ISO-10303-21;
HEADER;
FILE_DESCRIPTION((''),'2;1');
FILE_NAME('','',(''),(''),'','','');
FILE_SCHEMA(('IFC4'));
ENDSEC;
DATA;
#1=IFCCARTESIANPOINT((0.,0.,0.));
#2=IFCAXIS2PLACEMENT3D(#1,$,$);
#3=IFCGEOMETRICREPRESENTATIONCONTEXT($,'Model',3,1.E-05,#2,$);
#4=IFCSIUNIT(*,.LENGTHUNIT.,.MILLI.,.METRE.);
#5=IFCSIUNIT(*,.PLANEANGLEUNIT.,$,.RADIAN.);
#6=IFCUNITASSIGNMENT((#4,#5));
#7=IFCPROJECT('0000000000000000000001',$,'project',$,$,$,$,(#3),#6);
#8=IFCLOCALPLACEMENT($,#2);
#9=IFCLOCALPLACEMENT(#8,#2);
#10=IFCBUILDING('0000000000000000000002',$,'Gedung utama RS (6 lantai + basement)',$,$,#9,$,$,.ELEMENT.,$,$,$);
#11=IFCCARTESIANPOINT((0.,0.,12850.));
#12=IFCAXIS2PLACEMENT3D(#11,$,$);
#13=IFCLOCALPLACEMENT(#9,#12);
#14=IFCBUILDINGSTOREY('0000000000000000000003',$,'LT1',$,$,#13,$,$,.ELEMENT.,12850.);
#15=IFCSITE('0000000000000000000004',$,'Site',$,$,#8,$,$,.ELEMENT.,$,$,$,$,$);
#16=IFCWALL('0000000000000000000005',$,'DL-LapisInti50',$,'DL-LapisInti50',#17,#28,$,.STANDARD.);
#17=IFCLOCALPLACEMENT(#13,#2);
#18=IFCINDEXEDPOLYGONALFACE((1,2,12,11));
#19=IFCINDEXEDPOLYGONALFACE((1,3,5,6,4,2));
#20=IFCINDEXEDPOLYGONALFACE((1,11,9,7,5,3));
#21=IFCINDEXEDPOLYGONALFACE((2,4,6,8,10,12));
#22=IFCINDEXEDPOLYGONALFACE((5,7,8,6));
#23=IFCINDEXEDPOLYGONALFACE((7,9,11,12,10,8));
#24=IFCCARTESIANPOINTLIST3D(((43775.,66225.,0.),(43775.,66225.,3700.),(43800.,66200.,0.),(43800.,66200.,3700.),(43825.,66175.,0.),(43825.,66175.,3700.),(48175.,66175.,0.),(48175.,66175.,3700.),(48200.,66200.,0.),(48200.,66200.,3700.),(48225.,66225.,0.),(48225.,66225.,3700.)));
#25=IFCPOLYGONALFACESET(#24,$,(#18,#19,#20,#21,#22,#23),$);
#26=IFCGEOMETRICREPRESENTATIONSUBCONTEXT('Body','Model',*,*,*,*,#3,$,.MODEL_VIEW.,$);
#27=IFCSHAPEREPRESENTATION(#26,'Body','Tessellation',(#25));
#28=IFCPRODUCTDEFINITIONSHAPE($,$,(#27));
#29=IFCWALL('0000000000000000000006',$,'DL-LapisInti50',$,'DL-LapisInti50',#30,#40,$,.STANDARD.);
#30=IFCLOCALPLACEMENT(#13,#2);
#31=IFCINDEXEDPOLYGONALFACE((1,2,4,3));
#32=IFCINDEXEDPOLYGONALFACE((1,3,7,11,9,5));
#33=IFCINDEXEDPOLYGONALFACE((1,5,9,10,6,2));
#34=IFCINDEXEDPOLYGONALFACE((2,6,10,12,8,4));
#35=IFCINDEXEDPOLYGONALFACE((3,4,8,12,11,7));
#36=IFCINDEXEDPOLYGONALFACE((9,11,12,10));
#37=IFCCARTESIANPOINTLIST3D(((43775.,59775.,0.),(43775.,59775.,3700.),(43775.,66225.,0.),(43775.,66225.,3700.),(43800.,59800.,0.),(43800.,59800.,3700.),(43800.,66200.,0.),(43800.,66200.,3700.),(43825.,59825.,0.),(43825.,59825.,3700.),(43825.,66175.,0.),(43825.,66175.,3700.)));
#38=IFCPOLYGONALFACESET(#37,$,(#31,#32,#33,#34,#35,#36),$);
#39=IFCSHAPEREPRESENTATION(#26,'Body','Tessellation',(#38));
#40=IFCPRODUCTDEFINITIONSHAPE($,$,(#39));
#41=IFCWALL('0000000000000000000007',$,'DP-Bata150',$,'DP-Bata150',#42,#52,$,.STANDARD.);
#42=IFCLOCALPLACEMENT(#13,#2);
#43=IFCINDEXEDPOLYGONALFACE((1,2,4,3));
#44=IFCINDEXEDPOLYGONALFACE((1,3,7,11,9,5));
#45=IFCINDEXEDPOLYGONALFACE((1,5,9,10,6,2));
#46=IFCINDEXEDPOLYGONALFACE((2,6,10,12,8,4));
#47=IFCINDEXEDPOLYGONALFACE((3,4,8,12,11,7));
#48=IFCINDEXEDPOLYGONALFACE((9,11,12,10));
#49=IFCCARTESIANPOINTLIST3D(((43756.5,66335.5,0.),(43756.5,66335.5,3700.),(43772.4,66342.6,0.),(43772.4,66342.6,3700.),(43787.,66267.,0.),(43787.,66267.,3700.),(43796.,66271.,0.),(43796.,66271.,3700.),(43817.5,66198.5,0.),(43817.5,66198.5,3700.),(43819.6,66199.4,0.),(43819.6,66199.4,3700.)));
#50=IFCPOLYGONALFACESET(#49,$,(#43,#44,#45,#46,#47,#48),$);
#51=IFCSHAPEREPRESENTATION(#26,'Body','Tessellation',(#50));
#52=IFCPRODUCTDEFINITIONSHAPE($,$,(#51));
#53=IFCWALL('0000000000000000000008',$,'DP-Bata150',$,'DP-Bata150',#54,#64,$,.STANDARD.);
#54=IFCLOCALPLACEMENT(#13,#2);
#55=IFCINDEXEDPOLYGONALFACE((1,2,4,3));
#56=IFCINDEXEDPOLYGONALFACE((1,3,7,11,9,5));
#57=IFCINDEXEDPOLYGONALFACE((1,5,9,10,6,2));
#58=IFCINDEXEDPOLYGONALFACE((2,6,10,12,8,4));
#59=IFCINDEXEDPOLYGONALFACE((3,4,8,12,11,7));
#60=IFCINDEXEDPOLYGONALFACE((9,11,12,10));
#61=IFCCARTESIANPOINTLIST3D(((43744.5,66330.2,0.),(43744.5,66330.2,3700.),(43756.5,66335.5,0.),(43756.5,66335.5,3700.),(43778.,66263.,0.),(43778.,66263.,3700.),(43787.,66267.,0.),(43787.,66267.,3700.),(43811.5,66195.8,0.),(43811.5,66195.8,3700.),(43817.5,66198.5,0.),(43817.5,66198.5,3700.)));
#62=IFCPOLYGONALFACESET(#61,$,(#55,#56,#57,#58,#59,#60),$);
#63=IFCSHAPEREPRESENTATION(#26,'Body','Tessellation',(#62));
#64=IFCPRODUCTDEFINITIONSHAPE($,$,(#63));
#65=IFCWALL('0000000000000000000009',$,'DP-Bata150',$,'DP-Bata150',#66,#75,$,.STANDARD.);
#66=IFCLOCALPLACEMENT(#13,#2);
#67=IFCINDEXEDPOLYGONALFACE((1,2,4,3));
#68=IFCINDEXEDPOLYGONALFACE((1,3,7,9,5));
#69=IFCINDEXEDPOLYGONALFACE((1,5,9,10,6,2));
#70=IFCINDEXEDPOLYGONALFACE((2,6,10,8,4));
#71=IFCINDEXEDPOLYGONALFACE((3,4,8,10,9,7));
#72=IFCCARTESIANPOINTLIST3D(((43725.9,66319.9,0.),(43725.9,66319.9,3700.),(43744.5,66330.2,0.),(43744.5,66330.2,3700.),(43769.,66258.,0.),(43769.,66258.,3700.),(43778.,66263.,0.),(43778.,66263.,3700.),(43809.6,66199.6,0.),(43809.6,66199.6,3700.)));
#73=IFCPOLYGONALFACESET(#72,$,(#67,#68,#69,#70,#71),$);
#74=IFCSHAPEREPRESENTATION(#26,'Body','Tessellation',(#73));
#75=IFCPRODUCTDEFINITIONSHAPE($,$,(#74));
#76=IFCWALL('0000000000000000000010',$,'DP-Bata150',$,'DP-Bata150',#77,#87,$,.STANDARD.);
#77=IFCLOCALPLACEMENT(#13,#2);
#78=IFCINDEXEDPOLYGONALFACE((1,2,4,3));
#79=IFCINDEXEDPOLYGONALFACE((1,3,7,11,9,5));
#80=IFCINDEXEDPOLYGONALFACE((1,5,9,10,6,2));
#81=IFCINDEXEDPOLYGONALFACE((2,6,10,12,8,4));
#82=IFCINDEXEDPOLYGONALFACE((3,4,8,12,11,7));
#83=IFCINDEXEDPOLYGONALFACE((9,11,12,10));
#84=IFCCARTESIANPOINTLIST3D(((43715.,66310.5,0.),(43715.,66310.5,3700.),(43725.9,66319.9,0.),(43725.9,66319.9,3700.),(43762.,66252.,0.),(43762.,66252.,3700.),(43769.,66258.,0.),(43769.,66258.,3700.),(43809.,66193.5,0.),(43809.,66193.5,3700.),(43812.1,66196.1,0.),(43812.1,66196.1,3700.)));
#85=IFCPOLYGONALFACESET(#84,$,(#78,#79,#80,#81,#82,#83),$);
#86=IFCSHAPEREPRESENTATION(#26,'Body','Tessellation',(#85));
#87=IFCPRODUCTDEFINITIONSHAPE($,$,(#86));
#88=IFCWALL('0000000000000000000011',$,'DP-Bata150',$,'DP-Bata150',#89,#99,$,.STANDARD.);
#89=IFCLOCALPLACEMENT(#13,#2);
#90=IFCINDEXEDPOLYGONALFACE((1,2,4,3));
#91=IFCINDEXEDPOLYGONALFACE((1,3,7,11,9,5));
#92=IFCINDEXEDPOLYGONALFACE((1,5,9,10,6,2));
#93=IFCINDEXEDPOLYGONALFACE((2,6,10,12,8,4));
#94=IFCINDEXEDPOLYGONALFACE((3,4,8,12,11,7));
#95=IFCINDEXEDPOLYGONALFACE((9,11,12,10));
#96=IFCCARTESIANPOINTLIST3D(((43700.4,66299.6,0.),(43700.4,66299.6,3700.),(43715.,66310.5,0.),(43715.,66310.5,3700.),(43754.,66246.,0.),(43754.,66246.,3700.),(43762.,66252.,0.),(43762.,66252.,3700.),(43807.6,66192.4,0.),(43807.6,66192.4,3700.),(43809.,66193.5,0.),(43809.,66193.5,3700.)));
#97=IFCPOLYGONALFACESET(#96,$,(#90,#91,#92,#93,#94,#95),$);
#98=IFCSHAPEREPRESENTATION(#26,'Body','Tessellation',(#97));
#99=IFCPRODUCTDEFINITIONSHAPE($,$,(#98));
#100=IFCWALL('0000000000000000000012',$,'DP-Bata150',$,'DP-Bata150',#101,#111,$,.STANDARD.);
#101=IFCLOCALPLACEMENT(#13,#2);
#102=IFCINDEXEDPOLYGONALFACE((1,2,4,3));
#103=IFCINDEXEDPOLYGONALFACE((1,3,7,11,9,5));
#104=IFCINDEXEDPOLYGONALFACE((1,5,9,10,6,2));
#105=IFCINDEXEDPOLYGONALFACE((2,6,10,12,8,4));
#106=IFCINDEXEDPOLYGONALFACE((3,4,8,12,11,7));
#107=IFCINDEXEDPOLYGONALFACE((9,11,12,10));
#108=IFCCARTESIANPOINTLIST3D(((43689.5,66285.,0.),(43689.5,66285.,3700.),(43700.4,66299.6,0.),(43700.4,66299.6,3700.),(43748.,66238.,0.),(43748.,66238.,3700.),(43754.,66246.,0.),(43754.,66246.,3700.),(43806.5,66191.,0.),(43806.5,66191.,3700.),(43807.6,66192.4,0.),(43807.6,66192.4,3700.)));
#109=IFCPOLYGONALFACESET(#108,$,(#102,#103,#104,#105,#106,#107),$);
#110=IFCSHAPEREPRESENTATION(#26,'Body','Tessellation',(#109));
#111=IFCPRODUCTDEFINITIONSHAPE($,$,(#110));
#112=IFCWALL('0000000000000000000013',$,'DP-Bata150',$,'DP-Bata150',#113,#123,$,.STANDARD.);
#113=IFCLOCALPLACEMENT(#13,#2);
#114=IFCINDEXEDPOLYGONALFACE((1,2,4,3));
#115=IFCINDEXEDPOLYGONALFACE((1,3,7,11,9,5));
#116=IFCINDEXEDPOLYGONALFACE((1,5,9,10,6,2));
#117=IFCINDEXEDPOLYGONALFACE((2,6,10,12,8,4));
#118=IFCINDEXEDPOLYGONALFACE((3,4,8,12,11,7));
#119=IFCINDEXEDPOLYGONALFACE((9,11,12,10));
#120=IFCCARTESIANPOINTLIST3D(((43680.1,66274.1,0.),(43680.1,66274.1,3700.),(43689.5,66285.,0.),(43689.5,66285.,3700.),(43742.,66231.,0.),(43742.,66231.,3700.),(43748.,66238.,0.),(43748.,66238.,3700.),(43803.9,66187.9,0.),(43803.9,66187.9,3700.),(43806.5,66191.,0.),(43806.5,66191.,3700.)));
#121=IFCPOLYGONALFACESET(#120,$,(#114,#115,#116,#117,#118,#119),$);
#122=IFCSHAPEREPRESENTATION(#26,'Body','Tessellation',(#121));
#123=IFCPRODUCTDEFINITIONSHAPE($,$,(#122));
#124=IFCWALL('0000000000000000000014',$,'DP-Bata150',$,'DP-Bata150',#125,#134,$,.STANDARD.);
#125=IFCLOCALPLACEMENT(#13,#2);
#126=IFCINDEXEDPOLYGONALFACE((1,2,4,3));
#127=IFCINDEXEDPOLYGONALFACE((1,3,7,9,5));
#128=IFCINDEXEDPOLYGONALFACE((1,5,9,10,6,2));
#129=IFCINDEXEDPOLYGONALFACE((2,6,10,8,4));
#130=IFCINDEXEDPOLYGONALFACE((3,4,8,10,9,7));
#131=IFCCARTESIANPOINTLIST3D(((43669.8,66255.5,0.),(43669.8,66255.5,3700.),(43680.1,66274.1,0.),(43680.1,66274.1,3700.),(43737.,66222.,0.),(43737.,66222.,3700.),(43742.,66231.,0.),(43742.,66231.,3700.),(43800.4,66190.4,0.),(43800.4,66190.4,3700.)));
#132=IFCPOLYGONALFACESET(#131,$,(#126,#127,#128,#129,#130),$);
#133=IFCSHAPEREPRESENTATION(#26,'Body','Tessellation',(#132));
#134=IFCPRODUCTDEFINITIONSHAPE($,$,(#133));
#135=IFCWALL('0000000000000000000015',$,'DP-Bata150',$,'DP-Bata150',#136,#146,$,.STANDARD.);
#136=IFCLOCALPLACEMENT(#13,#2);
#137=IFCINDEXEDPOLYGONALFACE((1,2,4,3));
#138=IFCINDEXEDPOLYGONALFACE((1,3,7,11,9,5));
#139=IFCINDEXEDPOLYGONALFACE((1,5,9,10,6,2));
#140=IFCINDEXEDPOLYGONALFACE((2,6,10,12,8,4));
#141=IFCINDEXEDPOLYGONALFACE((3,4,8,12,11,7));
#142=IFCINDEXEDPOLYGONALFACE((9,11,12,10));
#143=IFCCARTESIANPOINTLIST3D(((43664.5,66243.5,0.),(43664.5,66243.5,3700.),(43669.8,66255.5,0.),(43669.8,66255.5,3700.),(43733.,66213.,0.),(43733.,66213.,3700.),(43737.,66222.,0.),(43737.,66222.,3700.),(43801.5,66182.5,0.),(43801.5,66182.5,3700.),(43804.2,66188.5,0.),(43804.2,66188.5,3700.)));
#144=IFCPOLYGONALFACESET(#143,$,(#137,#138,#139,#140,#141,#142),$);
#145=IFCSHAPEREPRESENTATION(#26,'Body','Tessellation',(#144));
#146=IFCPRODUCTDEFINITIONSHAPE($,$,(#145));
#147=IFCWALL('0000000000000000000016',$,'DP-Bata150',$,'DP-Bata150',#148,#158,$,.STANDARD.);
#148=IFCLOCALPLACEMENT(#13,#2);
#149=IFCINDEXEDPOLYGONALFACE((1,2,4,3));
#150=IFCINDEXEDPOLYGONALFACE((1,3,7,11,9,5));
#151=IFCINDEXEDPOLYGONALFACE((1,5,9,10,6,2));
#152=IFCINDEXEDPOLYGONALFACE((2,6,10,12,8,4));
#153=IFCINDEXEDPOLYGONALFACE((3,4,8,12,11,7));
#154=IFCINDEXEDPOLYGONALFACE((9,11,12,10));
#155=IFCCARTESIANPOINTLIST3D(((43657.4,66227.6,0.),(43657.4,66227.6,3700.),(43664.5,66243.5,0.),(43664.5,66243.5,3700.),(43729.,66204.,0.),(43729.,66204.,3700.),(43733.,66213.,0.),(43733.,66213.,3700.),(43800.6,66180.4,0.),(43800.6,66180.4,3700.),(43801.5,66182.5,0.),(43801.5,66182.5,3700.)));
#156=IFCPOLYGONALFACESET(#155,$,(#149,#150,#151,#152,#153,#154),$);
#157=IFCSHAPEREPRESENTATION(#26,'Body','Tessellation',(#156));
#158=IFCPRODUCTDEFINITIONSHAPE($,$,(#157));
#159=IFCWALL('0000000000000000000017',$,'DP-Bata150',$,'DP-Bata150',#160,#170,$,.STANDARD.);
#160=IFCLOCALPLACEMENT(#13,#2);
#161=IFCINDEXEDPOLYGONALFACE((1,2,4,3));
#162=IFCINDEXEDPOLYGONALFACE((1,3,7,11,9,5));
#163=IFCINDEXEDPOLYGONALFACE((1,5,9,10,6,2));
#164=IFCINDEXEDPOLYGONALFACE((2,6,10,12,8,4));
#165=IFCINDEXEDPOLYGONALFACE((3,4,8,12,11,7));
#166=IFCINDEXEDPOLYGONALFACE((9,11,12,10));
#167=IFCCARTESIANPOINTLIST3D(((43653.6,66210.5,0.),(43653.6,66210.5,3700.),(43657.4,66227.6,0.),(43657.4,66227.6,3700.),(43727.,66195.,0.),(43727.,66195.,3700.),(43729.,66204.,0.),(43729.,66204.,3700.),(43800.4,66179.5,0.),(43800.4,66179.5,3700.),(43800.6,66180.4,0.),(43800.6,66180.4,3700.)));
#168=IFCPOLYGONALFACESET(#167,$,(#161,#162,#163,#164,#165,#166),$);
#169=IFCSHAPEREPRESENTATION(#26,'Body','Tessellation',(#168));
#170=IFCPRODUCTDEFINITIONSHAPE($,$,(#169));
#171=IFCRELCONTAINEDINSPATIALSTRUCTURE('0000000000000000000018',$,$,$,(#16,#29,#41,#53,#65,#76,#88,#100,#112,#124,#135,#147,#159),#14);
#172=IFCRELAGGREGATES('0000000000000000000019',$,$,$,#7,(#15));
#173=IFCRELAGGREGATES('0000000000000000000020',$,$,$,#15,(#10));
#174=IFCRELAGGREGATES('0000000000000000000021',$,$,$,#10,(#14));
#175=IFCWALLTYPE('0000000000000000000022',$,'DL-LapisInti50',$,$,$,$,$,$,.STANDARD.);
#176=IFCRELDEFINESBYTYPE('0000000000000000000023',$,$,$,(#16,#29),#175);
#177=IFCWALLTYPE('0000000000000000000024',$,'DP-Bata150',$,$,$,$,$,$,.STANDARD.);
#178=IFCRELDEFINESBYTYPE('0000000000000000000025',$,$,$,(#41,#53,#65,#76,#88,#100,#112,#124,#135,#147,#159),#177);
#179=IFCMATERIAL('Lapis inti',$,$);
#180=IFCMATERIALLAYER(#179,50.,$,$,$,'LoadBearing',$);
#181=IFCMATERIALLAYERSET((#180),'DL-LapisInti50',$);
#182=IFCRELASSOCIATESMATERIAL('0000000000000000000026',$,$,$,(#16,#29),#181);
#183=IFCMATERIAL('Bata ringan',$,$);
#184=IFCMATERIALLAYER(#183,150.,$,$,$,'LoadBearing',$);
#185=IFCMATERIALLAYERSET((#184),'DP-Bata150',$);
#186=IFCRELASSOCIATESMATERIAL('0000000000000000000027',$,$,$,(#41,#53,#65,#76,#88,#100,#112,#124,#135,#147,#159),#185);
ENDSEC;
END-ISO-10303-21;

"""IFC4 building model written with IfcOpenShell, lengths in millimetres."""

from ifc_helpers import new_model, si_unit, frame, origin, place, context, subcontext, project, spatial, polyline, outline, extrude, material, layer, layer_set, layer_usage, type_object, element, save


model = new_model("IFC4")

# Units and contexts
model_context = context("Model", 3, precision=1e-05, world=origin())
body_context = subcontext(model_context, "Body", "Model", "MODEL_VIEW")
ifc_project = project(units=[si_unit("LENGTHUNIT", "METRE", prefix="MILLI"), si_unit("PLANEANGLEUNIT", "RADIAN")], contexts=[model_context])

# Site, building, storey
site_placement = place(None, origin())
site = spatial("IfcSite", under=ifc_project, at=site_placement, Name="Site", CompositionType="ELEMENT")
building_placement = place(site_placement, origin())
building = spatial("IfcBuilding", under=site, at=building_placement, Name="Gedung utama RS (6 lantai + basement)", CompositionType="ELEMENT")
storey_placement = place(building_placement, frame((0.0, 0.0, 12850.0)))
storey = spatial("IfcBuildingStorey", under=building, at=storey_placement, Name="LT1", CompositionType="ELEMENT", Elevation=12850.0)

# Walls
ifc_material_1 = material(Name="Lapis inti")
ifc_layer_1 = layer(ifc_material_1, 50.0, Category="LoadBearing")
ifc_layer_set_1 = layer_set([ifc_layer_1], Name="DL-LapisInti50")
ifc_layer_usage_1 = layer_usage(ifc_layer_set_1, "AXIS2", "NEGATIVE", 25.0)
wall_type_1 = type_object("IfcWallType", Name="DL-LapisInti50", PredefinedType="STANDARD")
wall_1_placement = place(storey_placement, frame((48200.0, 66200.0, 0.0), z_axis=(0.0, 0.0, 1.0), x_axis=(-1.0, 0.0, 0.0)))
element("IfcWall", 1, at=wall_1_placement, inside=storey, type_object=wall_type_1, material=ifc_layer_usage_1, Name="DL-LapisInti50", ObjectType="DL-LapisInti50", PredefinedType="STANDARD", context=body_context, shape_type="SweptSolid", body=[
    extrude(outline(polyline([(-25.0, -25.0), (0.0, 0.0), (25.0, 25.0), (4375.0, 25.0), (4400.0, 0.0), (4425.0, -25.0), (-25.0, -25.0)])), origin(), (0.0, 0.0, 1.0), 3700.0),
])
wall_2_placement = place(storey_placement, frame((43800.0, 66200.0, 0.0), z_axis=(0.0, 0.0, 1.0), x_axis=(0.0, -1.0, 0.0)))
element("IfcWall", 2, at=wall_2_placement, inside=storey, type_object=wall_type_1, material=ifc_layer_usage_1, Name="DL-LapisInti50", ObjectType="DL-LapisInti50", PredefinedType="STANDARD", context=body_context, shape_type="SweptSolid", body=[
    extrude(outline(polyline([(-25.0, -25.0), (0.0, 0.0), (25.0, 25.0), (6375.0, 25.0), (6400.0, 0.0), (6425.0, -25.0), (-25.0, -25.0)])), origin(), (0.0, 0.0, 1.0), 3700.0),
])
ifc_material_2 = material(Name="Bata ringan")
ifc_layer_2 = layer(ifc_material_2, 150.0, Category="LoadBearing")
ifc_layer_set_2 = layer_set([ifc_layer_2], Name="DP-Bata150")
ifc_layer_usage_2 = layer_usage(ifc_layer_set_2, "AXIS2", "NEGATIVE", 75.0)
wall_type_2 = type_object("IfcWallType", Name="DP-Bata150", PredefinedType="STANDARD")
wall_3_placement = place(storey_placement, frame((43796.0, 66271.0, 0.0), z_axis=(0.0, 0.0, 1.0), x_axis=(-0.913812, -0.406138, 0.0)))
element("IfcWall", 3, at=wall_3_placement, inside=storey, type_object=wall_type_2, material=ifc_layer_usage_2, Name="DP-Bata150", ObjectType="DP-Bata150", PredefinedType="STANDARD", context=body_context, shape_type="SweptSolid", body=[
    extrude(outline(polyline([(-7.5, -75.0), (0.0, 0.0), (7.5, 75.0), (9.8, 75.0), (9.8, 0.0), (9.8, -75.0), (-7.5, -75.0)])), origin(), (0.0, 0.0, 1.0), 3700.0),
])
wall_4_placement = place(storey_placement, frame((43787.0, 66267.0, 0.0), z_axis=(0.0, 0.0, 1.0), x_axis=(-0.913812, -0.406138, 0.0)))
element("IfcWall", 4, at=wall_4_placement, inside=storey, type_object=wall_type_2, material=ifc_layer_usage_2, Name="DP-Bata150", ObjectType="DP-Bata150", PredefinedType="STANDARD", context=body_context, shape_type="SweptSolid", body=[
    extrude(outline(polyline([(0.0, -75.0), (0.0, 0.0), (0.0, 75.0), (6.5, 75.0), (9.8, 0.0), (13.2, -75.0), (0.0, -75.0)])), origin(), (0.0, 0.0, 1.0), 3700.0),
])
wall_5_placement = place(storey_placement, frame((43778.0, 66263.0, 0.0), z_axis=(0.0, 0.0, 1.0), x_axis=(-0.874157, -0.485643, 0.0)))
element("IfcWall", 5, at=wall_5_placement, inside=storey, type_object=wall_type_2, material=ifc_layer_usage_2, Name="DP-Bata150", ObjectType="DP-Bata150", PredefinedType="STANDARD", context=body_context, shape_type="SweptSolid", body=[
    extrude(outline(polyline([(-3.3, -75.0), (0.0, 0.0), (3.3, 75.0), (2.7, 75.0), (10.3, 0.0), (17.9, -75.0), (-3.3, -75.0)])), origin(), (0.0, 0.0, 1.0), 3700.0),
])
wall_6_placement = place(storey_placement, frame((43769.0, 66258.0, 0.0), z_axis=(0.0, 0.0, 1.0), x_axis=(-0.759257, -0.650791, 0.0)))
element("IfcWall", 6, at=wall_6_placement, inside=storey, type_object=wall_type_2, material=ifc_layer_usage_2, Name="DP-Bata150", ObjectType="DP-Bata150", PredefinedType="STANDARD", context=body_context, shape_type="SweptSolid", body=[
    extrude(outline(polyline([(-7.6, -75.0), (0.0, 0.0), (7.6, 75.0), (11.7, 75.0), (9.2, 0.0), (6.8, -75.0), (-7.6, -75.0)])), origin(), (0.0, 0.0, 1.0), 3700.0),
])
wall_7_placement = place(storey_placement, frame((43762.0, 66252.0, 0.0), z_axis=(0.0, 0.0, 1.0), x_axis=(-0.8, -0.6, 0.0)))
element("IfcWall", 7, at=wall_7_placement, inside=storey, type_object=wall_type_2, material=ifc_layer_usage_2, Name="DP-Bata150", ObjectType="DP-Bata150", PredefinedType="STANDARD", context=body_context, shape_type="SweptSolid", body=[
    extrude(outline(polyline([(2.4, -75.0), (0.0, 0.0), (-2.4, 75.0), (-0.7, 75.0), (10.0, 0.0), (20.7, -75.0), (2.4, -75.0)])), origin(), (0.0, 0.0, 1.0), 3700.0),
])
wall_8_placement = place(storey_placement, frame((43754.0, 66246.0, 0.0), z_axis=(0.0, 0.0, 1.0), x_axis=(-0.6, -0.8, 0.0)))
element("IfcWall", 8, at=wall_8_placement, inside=storey, type_object=wall_type_2, material=ifc_layer_usage_2, Name="DP-Bata150", ObjectType="DP-Bata150", PredefinedType="STANDARD", context=body_context, shape_type="SweptSolid", body=[
    extrude(outline(polyline([(-10.7, -75.0), (0.0, 0.0), (10.7, 75.0), (12.4, 75.0), (10.0, 0.0), (7.6, -75.0), (-10.7, -75.0)])), origin(), (0.0, 0.0, 1.0), 3700.0),
])
wall_9_placement = place(storey_placement, frame((43748.0, 66238.0, 0.0), z_axis=(0.0, 0.0, 1.0), x_axis=(-0.650791, -0.759257, 0.0)))
element("IfcWall", 9, at=wall_9_placement, inside=storey, type_object=wall_type_2, material=ifc_layer_usage_2, Name="DP-Bata150", ObjectType="DP-Bata150", PredefinedType="STANDARD", context=body_context, shape_type="SweptSolid", body=[
    extrude(outline(polyline([(2.4, -75.0), (0.0, 0.0), (-2.4, 75.0), (1.6, 75.0), (9.2, 0.0), (16.8, -75.0), (2.4, -75.0)])), origin(), (0.0, 0.0, 1.0), 3700.0),
])
wall_10_placement = place(storey_placement, frame((43742.0, 66231.0, 0.0), z_axis=(0.0, 0.0, 1.0), x_axis=(-0.485643, -0.874157, 0.0)))
element("IfcWall", 10, at=wall_10_placement, inside=storey, type_object=wall_type_2, material=ifc_layer_usage_2, Name="DP-Bata150", ObjectType="DP-Bata150", PredefinedType="STANDARD", context=body_context, shape_type="SweptSolid", body=[
    extrude(outline(polyline([(-7.6, -75.0), (0.0, 0.0), (7.6, 75.0), (7.0, 75.0), (10.3, 0.0), (13.6, -75.0), (-7.6, -75.0)])), origin(), (0.0, 0.0, 1.0), 3700.0),
])
wall_11_placement = place(storey_placement, frame((43737.0, 66222.0, 0.0), z_axis=(0.0, 0.0, 1.0), x_axis=(-0.406138, -0.913812, 0.0)))
element("IfcWall", 11, at=wall_11_placement, inside=storey, type_object=wall_type_2, material=ifc_layer_usage_2, Name="DP-Bata150", ObjectType="DP-Bata150", PredefinedType="STANDARD", context=body_context, shape_type="SweptSolid", body=[
    extrude(outline(polyline([(-3.3, -75.0), (0.0, 0.0), (3.3, 75.0), (9.8, 75.0), (9.8, 0.0), (9.8, -75.0), (-3.3, -75.0)])), origin(), (0.0, 0.0, 1.0), 3700.0),
])
wall_12_placement = place(storey_placement, frame((43733.0, 66213.0, 0.0), z_axis=(0.0, 0.0, 1.0), x_axis=(-0.406138, -0.913812, 0.0)))
element("IfcWall", 12, at=wall_12_placement, inside=storey, type_object=wall_type_2, material=ifc_layer_usage_2, Name="DP-Bata150", ObjectType="DP-Bata150", PredefinedType="STANDARD", context=body_context, shape_type="SweptSolid", body=[
    extrude(outline(polyline([(0.0, -75.0), (0.0, 0.0), (0.0, 75.0), (2.3, 75.0), (9.8, 0.0), (17.4, -75.0), (0.0, -75.0)])), origin(), (0.0, 0.0, 1.0), 3700.0),
])
wall_13_placement = place(storey_placement, frame((43729.0, 66204.0, 0.0), z_axis=(0.0, 0.0, 1.0), x_axis=(-0.21693, -0.976187, 0.0)))
element("IfcWall", 13, at=wall_13_placement, inside=storey, type_object=wall_type_2, material=ifc_layer_usage_2, Name="DP-Bata150", ObjectType="DP-Bata150", PredefinedType="STANDARD", context=body_context, shape_type="SweptSolid", body=[
    extrude(outline(polyline([(-7.5, -75.0), (0.0, 0.0), (7.5, 75.0), (8.4, 75.0), (9.2, 0.0), (10.0, -75.0), (-7.5, -75.0)])), origin(), (0.0, 0.0, 1.0), 3700.0),
])

save(model, "model.ifc")
